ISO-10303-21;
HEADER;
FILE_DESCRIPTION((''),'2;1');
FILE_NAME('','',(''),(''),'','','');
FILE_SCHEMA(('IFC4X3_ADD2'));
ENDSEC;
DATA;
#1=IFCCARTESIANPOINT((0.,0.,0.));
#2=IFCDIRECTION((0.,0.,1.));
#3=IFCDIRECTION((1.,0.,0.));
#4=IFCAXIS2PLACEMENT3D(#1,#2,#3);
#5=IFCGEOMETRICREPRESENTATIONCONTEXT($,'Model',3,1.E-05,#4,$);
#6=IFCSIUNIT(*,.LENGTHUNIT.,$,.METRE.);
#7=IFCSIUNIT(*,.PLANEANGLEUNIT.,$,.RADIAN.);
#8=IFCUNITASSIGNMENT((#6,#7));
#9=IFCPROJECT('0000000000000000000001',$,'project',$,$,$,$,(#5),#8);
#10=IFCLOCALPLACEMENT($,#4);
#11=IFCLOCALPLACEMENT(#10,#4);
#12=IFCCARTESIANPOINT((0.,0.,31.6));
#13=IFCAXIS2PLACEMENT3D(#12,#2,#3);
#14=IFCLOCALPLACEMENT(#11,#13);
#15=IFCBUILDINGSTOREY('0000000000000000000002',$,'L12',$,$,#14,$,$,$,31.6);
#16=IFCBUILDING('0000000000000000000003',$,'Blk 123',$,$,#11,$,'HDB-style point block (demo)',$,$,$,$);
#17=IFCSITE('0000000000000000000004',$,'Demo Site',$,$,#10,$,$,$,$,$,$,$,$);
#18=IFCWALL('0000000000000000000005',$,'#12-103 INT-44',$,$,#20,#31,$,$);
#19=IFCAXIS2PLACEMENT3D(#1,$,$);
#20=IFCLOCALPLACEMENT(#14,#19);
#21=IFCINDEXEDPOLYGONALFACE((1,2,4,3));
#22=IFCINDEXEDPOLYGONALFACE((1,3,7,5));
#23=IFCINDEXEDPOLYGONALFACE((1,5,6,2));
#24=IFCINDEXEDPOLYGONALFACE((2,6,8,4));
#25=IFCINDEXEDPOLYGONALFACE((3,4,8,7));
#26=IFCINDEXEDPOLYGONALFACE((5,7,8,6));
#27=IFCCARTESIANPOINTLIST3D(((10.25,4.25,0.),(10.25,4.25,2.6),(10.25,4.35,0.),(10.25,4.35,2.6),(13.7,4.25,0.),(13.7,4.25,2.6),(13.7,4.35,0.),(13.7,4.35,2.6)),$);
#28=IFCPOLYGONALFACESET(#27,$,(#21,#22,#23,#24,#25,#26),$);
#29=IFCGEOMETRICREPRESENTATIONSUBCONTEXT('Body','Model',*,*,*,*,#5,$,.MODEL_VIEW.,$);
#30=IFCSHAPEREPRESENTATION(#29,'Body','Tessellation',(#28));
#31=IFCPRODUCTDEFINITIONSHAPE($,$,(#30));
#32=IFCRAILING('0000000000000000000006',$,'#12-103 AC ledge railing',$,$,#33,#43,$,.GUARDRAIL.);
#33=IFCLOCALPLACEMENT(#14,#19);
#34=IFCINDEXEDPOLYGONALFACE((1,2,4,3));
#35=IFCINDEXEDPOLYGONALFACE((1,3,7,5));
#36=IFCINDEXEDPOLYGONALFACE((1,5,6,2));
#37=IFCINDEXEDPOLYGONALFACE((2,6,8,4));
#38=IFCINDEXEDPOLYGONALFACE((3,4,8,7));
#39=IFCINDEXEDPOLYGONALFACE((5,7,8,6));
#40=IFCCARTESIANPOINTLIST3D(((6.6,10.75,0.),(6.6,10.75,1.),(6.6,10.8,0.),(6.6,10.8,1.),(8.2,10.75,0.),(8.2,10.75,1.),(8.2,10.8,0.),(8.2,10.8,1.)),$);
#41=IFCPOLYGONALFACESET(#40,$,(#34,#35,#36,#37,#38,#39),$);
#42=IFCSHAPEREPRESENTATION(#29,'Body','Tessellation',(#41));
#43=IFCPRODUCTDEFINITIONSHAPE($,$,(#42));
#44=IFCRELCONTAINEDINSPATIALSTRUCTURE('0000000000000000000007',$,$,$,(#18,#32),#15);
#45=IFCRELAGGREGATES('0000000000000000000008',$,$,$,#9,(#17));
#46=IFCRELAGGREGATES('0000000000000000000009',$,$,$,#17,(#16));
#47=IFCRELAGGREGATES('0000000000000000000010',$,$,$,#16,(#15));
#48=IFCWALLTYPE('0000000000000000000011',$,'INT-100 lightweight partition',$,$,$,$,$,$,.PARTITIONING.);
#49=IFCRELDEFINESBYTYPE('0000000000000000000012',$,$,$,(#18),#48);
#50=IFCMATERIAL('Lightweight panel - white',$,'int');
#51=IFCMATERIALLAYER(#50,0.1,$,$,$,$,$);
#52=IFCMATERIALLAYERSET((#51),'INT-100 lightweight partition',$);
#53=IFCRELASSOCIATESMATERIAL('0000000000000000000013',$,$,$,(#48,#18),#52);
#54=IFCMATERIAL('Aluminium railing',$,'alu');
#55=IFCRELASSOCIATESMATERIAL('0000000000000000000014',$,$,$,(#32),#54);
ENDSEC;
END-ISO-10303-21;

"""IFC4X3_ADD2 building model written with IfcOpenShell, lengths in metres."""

from ifc_helpers import new_model, si_unit, frame, origin, origin_with_axes, place, context, subcontext, project, spatial, polyline, indexed_curve, outline, extrude, material, layer, layer_set, layer_usage, type_object, element, save


model = new_model("IFC4X3_ADD2")

# Units and contexts
model_context = context("Model", 3, precision=1e-05, world=origin_with_axes())
body_context = subcontext(model_context, "Body", "Model", "MODEL_VIEW")
ifc_project = project(units=[si_unit("LENGTHUNIT", "METRE"), si_unit("PLANEANGLEUNIT", "RADIAN")], contexts=[model_context])

# Site, building, storey
site_placement = place(None, origin_with_axes())
site = spatial("IfcSite", under=ifc_project, at=site_placement, Name="Demo Site")
building_placement = place(site_placement, origin_with_axes())
building = spatial("IfcBuilding", under=site, at=building_placement, Name="Blk 123", LongName="HDB-style point block (demo)")
storey_placement = place(building_placement, frame((0.0, 0.0, 31.6), z_axis=(0.0, 0.0, 1.0), x_axis=(1.0, 0.0, 0.0)))
storey = spatial("IfcBuildingStorey", under=building, at=storey_placement, Name="L12", Elevation=31.6)

# Wall
ifc_material_1 = material(Name="Lightweight panel - white", Category="int")
ifc_layer_1 = layer(ifc_material_1, 0.1)
ifc_layer_set_1 = layer_set([ifc_layer_1], Name="INT-100 lightweight partition")
ifc_layer_usage_1 = layer_usage(ifc_layer_set_1, "AXIS2", "POSITIVE", -0.05)
wall_type_1 = type_object("IfcWallType", Name="INT-100 lightweight partition", PredefinedType="PARTITIONING", material=ifc_layer_set_1)
wall_1_placement = place(storey_placement, frame((10.25, 4.3, 0.0), z_axis=(0.0, 0.0, 1.0), x_axis=(1.0, 0.0, 0.0)))
element("IfcWall", 1, at=wall_1_placement, inside=storey, type_object=wall_type_1, material=ifc_layer_usage_1, Name="#12-103 INT-44", context=body_context, shape_type="SweptSolid", body=[
    extrude(outline(indexed_curve([(0.0, 0.0), (0.0, 0.1), (3.45, 0.1), (3.45, 0.0), (0.0, 0.0)], self_intersect=False)), frame((0.0, -0.05, 0.0), z_axis=(0.0, 0.0, 1.0), x_axis=(1.0, 0.0, 0.0)), (0.0, 0.0, 1.0), 2.6),
])

# Railing
ifc_material_2 = material(Name="Aluminium railing", Category="alu")
railing_placement = place(storey_placement, frame((7.4, 10.775, 0.0), z_axis=(0.0, 0.0, 1.0), x_axis=(1.0, 0.0, 0.0)))
element("IfcRailing", 2, at=railing_placement, inside=storey, material=ifc_material_2, Name="#12-103 AC ledge railing", PredefinedType="GUARDRAIL", context=body_context, shape_type="SweptSolid", body=[
    extrude(outline(polyline([(0.8, -0.025), (0.8, 0.025), (-0.8, 0.025), (-0.8, -0.025), (0.8, -0.025)])), origin(), (0.0, 0.0, 1.0), 1.0),
])

save(model, "model.ifc")
